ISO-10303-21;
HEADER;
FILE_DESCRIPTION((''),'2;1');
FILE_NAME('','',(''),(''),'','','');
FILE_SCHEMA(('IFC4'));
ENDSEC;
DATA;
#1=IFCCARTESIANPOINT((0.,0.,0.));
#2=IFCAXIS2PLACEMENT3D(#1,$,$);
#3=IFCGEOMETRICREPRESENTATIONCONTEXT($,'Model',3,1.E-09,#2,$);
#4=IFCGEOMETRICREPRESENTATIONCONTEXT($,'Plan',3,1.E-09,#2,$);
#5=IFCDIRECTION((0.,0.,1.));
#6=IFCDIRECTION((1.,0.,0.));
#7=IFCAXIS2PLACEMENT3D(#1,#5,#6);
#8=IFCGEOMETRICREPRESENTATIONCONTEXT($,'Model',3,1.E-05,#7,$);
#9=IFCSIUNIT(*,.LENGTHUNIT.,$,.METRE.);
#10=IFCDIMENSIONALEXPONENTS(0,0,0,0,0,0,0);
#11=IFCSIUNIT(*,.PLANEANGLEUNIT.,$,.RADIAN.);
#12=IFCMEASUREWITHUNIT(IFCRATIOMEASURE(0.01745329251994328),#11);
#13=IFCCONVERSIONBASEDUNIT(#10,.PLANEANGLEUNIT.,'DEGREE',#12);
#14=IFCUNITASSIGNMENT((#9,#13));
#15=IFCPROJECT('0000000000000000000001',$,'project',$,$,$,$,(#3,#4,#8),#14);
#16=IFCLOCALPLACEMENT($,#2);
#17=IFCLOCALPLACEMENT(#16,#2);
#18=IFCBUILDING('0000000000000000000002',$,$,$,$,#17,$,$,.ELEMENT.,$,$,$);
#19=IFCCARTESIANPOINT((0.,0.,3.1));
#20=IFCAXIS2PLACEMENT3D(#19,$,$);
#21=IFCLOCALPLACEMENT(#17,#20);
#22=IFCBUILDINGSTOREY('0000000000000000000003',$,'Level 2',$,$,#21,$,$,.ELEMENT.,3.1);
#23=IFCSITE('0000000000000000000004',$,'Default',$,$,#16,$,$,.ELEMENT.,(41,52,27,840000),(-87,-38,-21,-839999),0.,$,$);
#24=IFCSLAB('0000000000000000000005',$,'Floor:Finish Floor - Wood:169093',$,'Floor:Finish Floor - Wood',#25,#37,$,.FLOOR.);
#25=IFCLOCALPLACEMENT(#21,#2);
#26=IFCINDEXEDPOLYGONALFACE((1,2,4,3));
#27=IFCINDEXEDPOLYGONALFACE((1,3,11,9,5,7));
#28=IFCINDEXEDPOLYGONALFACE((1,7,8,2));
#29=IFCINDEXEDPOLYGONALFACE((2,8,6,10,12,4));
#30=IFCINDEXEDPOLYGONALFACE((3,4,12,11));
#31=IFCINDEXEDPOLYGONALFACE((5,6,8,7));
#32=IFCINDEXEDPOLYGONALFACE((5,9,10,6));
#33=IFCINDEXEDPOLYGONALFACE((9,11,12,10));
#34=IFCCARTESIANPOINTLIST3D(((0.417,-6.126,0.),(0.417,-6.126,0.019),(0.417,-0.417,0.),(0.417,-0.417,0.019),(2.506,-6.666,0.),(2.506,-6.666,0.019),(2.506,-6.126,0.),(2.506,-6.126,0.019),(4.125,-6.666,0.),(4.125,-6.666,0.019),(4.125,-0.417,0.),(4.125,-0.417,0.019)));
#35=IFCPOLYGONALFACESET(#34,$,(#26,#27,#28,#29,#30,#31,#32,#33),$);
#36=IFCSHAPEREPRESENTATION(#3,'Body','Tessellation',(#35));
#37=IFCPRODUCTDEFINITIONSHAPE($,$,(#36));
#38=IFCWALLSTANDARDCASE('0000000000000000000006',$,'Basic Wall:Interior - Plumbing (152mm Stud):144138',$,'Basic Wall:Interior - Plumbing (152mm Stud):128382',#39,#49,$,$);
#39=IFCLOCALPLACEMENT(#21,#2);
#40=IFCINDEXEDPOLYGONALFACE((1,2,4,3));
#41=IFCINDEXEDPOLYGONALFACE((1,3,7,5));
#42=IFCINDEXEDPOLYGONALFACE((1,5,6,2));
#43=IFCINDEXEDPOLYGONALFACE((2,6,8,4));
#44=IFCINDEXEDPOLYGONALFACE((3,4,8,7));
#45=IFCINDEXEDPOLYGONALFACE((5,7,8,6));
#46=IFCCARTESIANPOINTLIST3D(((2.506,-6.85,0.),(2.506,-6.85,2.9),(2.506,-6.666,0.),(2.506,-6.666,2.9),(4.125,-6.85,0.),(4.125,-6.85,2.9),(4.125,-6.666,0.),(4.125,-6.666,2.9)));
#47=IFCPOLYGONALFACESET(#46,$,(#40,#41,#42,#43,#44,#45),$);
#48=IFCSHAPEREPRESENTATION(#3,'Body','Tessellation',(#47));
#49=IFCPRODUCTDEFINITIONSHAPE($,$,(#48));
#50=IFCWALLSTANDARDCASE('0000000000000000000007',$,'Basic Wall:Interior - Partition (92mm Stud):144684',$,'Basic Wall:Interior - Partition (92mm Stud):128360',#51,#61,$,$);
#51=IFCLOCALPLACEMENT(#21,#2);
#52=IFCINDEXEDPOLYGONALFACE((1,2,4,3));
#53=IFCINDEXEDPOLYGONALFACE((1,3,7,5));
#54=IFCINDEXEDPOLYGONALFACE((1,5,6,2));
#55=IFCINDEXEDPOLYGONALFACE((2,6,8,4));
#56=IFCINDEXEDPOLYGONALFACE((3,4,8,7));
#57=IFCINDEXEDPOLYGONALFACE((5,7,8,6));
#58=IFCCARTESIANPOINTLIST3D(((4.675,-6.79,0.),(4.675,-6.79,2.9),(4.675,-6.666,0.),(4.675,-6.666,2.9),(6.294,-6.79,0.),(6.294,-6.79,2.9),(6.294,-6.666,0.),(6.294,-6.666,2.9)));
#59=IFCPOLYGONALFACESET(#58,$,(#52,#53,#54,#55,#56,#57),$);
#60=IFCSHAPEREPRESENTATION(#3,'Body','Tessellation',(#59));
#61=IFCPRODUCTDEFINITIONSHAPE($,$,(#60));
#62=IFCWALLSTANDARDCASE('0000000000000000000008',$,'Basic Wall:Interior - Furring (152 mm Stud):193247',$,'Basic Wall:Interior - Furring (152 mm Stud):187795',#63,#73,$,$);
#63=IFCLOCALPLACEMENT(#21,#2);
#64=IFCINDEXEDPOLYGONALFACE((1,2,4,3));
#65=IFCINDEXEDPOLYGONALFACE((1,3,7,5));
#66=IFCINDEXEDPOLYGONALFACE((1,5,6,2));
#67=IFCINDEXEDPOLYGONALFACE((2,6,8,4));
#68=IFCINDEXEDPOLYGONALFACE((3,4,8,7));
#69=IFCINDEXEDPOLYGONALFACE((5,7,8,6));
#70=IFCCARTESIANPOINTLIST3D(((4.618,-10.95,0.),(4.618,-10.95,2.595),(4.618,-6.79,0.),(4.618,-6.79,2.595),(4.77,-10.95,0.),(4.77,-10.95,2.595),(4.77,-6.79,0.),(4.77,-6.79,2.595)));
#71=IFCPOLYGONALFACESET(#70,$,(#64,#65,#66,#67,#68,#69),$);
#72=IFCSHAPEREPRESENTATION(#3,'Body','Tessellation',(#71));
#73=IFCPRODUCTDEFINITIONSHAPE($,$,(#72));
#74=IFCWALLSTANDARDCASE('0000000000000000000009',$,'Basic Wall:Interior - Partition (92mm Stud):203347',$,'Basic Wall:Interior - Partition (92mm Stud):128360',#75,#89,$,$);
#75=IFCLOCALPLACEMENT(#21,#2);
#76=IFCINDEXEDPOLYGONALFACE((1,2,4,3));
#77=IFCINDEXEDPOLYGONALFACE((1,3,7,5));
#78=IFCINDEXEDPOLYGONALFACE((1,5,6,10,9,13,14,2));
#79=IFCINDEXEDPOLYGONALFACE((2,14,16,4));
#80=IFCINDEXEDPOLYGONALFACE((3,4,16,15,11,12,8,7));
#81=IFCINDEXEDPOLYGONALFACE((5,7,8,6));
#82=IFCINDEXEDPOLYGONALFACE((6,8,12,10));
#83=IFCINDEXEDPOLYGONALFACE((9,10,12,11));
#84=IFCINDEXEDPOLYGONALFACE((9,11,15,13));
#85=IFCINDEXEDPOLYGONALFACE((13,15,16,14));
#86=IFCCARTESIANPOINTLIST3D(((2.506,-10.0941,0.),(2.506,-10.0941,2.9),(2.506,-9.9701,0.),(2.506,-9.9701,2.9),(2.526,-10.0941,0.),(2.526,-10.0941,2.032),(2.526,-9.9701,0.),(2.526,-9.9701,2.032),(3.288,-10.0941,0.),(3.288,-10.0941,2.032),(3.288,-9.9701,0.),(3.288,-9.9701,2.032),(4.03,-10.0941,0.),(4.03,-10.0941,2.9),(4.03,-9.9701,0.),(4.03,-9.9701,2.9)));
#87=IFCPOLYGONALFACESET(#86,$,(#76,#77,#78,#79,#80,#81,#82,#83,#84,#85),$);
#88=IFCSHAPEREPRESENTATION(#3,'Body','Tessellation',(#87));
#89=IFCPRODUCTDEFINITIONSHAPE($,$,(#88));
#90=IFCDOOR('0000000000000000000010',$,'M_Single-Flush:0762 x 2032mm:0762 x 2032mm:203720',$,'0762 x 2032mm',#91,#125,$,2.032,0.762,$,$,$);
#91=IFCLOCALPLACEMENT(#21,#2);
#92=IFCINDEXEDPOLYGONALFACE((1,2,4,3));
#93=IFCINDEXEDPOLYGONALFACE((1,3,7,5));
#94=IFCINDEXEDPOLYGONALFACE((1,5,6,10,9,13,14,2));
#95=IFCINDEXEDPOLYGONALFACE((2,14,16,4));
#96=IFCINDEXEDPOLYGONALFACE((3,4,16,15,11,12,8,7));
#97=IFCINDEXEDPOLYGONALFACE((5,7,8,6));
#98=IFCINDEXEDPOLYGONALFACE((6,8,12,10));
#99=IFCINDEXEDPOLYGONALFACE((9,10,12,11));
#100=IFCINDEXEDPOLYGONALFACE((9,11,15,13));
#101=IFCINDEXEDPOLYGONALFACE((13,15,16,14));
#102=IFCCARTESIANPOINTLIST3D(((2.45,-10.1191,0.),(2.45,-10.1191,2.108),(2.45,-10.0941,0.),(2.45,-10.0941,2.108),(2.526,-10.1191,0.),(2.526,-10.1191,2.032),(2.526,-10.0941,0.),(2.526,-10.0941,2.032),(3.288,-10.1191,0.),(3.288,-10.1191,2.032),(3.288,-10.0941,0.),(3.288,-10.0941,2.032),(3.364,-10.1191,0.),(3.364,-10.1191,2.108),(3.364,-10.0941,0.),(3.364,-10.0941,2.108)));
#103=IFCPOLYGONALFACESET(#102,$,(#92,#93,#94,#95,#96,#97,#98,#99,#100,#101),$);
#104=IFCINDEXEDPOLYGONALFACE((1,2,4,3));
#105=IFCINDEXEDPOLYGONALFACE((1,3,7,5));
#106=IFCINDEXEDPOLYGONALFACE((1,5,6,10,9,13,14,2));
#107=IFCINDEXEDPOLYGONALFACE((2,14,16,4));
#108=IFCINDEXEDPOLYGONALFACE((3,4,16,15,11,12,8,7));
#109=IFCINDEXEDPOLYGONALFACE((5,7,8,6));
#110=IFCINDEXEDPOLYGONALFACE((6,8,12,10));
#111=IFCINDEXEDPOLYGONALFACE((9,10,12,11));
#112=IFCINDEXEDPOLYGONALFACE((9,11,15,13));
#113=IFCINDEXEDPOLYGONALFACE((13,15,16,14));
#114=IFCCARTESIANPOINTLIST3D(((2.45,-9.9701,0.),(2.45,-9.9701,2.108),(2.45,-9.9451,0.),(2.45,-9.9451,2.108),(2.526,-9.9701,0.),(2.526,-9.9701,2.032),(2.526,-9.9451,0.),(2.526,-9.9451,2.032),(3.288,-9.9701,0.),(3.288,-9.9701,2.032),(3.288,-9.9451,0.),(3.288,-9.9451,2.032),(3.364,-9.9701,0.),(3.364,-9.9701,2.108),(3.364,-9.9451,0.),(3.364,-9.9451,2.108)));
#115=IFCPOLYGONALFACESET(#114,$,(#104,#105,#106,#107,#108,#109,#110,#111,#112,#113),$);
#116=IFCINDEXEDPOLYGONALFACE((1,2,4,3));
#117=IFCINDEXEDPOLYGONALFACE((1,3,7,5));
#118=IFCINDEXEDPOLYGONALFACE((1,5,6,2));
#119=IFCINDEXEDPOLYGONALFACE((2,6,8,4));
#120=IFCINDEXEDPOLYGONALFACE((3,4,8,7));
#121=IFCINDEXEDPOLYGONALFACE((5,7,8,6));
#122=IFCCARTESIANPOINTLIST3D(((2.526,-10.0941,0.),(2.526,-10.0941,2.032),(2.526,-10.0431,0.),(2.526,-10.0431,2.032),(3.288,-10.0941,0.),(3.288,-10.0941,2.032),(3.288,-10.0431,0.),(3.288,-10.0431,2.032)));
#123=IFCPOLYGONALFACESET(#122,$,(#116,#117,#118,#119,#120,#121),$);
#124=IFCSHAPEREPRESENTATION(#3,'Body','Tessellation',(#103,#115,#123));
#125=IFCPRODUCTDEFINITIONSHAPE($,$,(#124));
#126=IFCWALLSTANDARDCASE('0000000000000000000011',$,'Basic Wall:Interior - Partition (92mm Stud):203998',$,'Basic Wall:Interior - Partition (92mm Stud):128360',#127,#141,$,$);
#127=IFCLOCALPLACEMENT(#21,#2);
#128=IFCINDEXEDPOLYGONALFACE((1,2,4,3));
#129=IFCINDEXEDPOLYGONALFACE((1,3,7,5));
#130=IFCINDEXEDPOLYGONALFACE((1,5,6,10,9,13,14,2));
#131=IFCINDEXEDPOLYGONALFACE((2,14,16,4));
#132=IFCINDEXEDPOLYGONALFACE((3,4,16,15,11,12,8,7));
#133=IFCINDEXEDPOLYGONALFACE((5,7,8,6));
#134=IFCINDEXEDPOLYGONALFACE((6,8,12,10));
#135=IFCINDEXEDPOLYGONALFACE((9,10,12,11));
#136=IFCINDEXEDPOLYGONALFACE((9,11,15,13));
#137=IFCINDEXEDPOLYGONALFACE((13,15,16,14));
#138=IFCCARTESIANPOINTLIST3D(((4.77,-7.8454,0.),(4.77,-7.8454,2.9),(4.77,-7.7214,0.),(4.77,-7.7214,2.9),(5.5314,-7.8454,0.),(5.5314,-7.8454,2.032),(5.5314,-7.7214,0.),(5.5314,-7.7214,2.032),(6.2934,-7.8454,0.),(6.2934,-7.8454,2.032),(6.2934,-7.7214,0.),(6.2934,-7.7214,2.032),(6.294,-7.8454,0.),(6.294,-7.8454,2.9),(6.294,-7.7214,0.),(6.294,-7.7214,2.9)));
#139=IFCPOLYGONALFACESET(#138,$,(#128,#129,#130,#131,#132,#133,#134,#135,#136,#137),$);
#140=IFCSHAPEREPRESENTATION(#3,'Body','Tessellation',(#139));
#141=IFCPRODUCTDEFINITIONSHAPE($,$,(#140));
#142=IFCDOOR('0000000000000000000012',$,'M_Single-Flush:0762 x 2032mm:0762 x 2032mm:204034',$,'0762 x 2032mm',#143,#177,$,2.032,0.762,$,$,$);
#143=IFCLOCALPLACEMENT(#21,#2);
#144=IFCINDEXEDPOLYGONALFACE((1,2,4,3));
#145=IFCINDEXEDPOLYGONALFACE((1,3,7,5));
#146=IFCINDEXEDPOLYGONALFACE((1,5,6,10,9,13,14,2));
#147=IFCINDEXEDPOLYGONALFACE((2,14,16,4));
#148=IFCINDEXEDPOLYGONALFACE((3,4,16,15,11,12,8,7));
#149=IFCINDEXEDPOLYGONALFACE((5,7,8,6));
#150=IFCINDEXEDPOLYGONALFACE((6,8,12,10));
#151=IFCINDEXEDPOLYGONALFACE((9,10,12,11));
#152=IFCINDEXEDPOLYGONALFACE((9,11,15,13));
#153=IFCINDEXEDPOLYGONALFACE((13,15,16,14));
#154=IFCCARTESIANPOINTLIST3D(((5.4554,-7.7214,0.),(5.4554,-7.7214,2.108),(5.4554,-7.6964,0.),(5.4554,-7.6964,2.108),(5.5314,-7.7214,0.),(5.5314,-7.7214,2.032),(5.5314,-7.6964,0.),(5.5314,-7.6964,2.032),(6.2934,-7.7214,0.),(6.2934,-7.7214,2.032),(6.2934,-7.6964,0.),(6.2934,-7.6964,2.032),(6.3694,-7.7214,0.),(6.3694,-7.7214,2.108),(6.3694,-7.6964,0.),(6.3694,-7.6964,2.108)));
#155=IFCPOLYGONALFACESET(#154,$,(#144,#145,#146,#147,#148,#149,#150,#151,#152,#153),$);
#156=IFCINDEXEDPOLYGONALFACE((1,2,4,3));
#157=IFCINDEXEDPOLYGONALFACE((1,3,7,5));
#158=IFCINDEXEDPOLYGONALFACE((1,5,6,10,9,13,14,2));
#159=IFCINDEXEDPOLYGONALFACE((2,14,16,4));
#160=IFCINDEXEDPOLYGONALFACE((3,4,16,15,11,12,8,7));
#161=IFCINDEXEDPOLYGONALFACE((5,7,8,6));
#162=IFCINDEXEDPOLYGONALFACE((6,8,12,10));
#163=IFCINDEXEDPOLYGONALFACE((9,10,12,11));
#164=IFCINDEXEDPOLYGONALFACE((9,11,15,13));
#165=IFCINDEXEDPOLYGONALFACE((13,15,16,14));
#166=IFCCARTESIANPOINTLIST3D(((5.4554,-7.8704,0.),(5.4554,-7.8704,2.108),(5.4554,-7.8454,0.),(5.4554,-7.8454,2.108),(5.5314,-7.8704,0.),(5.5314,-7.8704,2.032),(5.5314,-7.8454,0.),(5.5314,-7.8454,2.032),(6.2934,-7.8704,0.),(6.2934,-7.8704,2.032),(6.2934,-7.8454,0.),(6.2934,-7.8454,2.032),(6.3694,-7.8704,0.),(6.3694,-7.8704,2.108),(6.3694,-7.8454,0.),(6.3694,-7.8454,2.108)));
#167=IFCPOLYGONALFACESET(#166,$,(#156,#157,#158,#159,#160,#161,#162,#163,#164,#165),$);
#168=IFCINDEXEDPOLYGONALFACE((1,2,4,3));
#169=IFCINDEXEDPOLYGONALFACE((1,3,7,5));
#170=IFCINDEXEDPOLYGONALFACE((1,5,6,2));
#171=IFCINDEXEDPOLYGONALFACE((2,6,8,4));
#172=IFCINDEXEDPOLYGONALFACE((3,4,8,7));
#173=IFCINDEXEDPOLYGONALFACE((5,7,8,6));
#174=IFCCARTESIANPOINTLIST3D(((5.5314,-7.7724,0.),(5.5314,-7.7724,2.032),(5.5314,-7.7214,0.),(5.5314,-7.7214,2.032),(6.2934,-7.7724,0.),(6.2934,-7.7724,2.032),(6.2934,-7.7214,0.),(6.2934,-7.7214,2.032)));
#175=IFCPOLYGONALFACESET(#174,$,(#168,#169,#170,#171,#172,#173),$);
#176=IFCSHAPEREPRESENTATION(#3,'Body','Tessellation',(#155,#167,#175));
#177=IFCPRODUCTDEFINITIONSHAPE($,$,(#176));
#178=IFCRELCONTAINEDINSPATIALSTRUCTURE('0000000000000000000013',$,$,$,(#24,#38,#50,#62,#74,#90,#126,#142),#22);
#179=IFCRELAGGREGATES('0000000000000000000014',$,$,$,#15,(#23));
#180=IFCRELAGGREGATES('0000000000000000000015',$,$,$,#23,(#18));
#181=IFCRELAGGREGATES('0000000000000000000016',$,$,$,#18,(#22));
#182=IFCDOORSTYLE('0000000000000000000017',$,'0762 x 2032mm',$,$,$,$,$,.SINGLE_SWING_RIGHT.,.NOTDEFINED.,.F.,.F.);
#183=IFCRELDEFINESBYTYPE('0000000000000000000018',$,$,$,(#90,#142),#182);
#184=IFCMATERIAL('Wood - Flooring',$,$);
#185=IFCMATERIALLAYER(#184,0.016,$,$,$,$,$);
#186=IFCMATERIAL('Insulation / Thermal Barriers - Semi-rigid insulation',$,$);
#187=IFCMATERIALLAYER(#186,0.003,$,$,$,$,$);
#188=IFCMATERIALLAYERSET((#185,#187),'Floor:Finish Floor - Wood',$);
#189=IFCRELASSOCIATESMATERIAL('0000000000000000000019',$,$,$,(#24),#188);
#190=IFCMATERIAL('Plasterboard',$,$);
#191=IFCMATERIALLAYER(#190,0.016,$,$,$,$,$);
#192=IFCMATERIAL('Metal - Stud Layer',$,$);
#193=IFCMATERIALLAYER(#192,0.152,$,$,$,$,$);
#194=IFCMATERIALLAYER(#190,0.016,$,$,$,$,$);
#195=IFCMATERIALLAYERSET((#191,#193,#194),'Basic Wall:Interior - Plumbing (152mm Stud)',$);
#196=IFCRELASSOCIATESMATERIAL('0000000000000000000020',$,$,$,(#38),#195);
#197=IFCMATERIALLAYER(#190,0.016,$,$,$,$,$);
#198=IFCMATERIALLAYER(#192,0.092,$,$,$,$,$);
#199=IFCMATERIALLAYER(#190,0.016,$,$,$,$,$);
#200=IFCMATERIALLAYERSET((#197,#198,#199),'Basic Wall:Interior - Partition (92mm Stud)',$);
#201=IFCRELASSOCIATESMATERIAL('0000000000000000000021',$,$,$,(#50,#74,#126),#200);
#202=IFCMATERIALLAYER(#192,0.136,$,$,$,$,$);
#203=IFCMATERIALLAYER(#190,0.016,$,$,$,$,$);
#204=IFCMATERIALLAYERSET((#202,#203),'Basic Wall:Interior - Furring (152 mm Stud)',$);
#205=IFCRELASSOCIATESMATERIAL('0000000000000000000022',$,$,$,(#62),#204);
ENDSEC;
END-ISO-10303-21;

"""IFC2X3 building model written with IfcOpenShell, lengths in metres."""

from ifc_helpers import new_model, entity, si_unit, converted_unit, frame, frame_2d, origin, origin_with_axes, origin_2d_with_axis, place, context, project, spatial, polyline, rectangle, outline, extrude, source, transform, mapped, material, layer, layer_set, layer_usage, type_object, type_shapes, element, fill, save


model = new_model("IFC2X3")

# Units and contexts
model_context_1 = context("Model", 3, precision=1e-09, world=origin())
plan_context = context("Plan", 3, precision=1e-09, world=origin())
model_context_2 = context("Model", 3, precision=1e-05, world=origin_with_axes())
ifc_project = project(units=[si_unit("LENGTHUNIT", "METRE"), converted_unit("PLANEANGLEUNIT", "DEGREE", entity("IfcRatioMeasure", 0.01745329251994328), si_unit("PLANEANGLEUNIT", "RADIAN"), dimensions=[0, 0, 0, 0, 0, 0, 0])], contexts=[model_context_1, plan_context, model_context_2])

# Site, building, storey
site_placement = place(None, origin())
site = spatial("IfcSite", under=ifc_project, at=site_placement, Name="Default", CompositionType="ELEMENT", RefLatitude=(41, 52, 27, 840000), RefLongitude=(-87, -38, -21, -839999), RefElevation=0.0)
building_placement = place(site_placement, origin())
building = spatial("IfcBuilding", under=site, at=building_placement, CompositionType="ELEMENT")
storey_placement = place(building_placement, frame((0.0, 0.0, 3.1)))
storey = spatial("IfcBuildingStorey", under=building, at=storey_placement, Name="Level 2", CompositionType="ELEMENT", Elevation=3.1)

# Slab
ifc_material_1 = material(Name="Wood - Flooring")
ifc_layer_1 = layer(ifc_material_1, 0.016)
ifc_material_2 = material(Name="Insulation / Thermal Barriers - Semi-rigid insulation")
ifc_layer_2 = layer(ifc_material_2, 0.003)
ifc_layer_set_1 = layer_set([ifc_layer_1, ifc_layer_2], Name="Floor:Finish Floor - Wood")
ifc_layer_usage_1 = layer_usage(ifc_layer_set_1, "AXIS3", "POSITIVE", 0.0)
slab_placement = place(storey_placement, frame((0.417, -6.666, 0.0)))
element("IfcSlab", 1, at=slab_placement, inside=storey, material=ifc_layer_usage_1, Name="Floor:Finish Floor - Wood:169093", ObjectType="Floor:Finish Floor - Wood", PredefinedType="FLOOR", context=model_context_1, shape_type="SweptSolid", body=[
    extrude(outline(polyline([(1.854, 3.1245), (-1.854, 3.1245), (-1.854, -3.1245), (-0.235, -3.1245), (-0.235, -2.5845), (1.854, -2.5845), (1.854, 3.1245)])), frame((1.854, 3.1245, 0.019), z_axis=(0.0, 0.0, -1.0), x_axis=(-1.0, 0.0, 0.0)), (0.0, 0.0, 1.0), 0.019),
])

# Walls
ifc_material_3 = material(Name="Plasterboard")
ifc_layer_3 = layer(ifc_material_3, 0.016)
ifc_material_4 = material(Name="Metal - Stud Layer")
ifc_layer_4 = layer(ifc_material_4, 0.152)
ifc_layer_5 = layer(ifc_material_3, 0.016)
ifc_layer_set_2 = layer_set([ifc_layer_3, ifc_layer_4, ifc_layer_5], Name="Basic Wall:Interior - Plumbing (152mm Stud)")
ifc_layer_usage_2 = layer_usage(ifc_layer_set_2, "AXIS2", "NEGATIVE", 0.092)
wall_1_placement = place(storey_placement, frame((2.506, -6.758, 0.0)))
element("IfcWallStandardCase", 2, at=wall_1_placement, inside=storey, material=ifc_layer_usage_2, Name="Basic Wall:Interior - Plumbing (152mm Stud):144138", ObjectType="Basic Wall:Interior - Plumbing (152mm Stud):128382", context=model_context_1, shape_type="SweptSolid", body=[
    extrude(rectangle(XDim=1.619, YDim=0.184, at=frame_2d((0.8095, 0.0), x_axis=(-1.0, 0.0))), origin(), (0.0, 0.0, 1.0), 2.9),
])
ifc_layer_6 = layer(ifc_material_3, 0.016)
ifc_layer_7 = layer(ifc_material_4, 0.092)
ifc_layer_8 = layer(ifc_material_3, 0.016)
ifc_layer_set_3 = layer_set([ifc_layer_6, ifc_layer_7, ifc_layer_8], Name="Basic Wall:Interior - Partition (92mm Stud)")
ifc_layer_usage_3 = layer_usage(ifc_layer_set_3, "AXIS2", "NEGATIVE", 0.062)
wall_2_placement = place(storey_placement, frame((4.675, -6.728, 0.0)))
element("IfcWallStandardCase", 3, at=wall_2_placement, inside=storey, material=ifc_layer_usage_3, Name="Basic Wall:Interior - Partition (92mm Stud):144684", ObjectType="Basic Wall:Interior - Partition (92mm Stud):128360", context=model_context_1, shape_type="SweptSolid", body=[
    extrude(rectangle(XDim=1.619, YDim=0.124, at=frame_2d((0.8095, 0.0), x_axis=(-1.0, 0.0))), origin(), (0.0, 0.0, 1.0), 2.9),
])
ifc_layer_9 = layer(ifc_material_4, 0.136)
ifc_layer_10 = layer(ifc_material_3, 0.016)
ifc_layer_set_4 = layer_set([ifc_layer_9, ifc_layer_10], Name="Basic Wall:Interior - Furring (152 mm Stud)")
ifc_layer_usage_4 = layer_usage(ifc_layer_set_4, "AXIS2", "POSITIVE", -0.076)
wall_3_placement = place(storey_placement, frame((4.694, -6.79, 0.0), z_axis=(0.0, 0.0, 1.0), x_axis=(0.0, -1.0, 0.0)))
element("IfcWallStandardCase", 4, at=wall_3_placement, inside=storey, material=ifc_layer_usage_4, Name="Basic Wall:Interior - Furring (152 mm Stud):193247", ObjectType="Basic Wall:Interior - Furring (152 mm Stud):187795", context=model_context_1, shape_type="SweptSolid", body=[
    extrude(rectangle(XDim=4.16, YDim=0.152, at=frame_2d((2.08, 0.0), x_axis=(-1.0, 0.0))), origin(), (0.0, 0.0, 1.0), 2.595),
])

# Walls, openings, doors
ifc_layer_usage_5 = layer_usage(ifc_layer_set_3, "AXIS2", "NEGATIVE", 0.062)
wall_4_placement = place(storey_placement, frame((4.03, -10.0321, 0.0), z_axis=(0.0, 0.0, 1.0), x_axis=(-1.0, 0.0, 0.0)))
wall_4 = element("IfcWallStandardCase", 5, at=wall_4_placement, inside=storey, material=ifc_layer_usage_5, Name="Basic Wall:Interior - Partition (92mm Stud):203347", ObjectType="Basic Wall:Interior - Partition (92mm Stud):128360", context=model_context_1, shape_type="SweptSolid", body=[
    extrude(rectangle(XDim=1.524, YDim=0.124, at=frame_2d((0.762, 0.0), x_axis=(-1.0, 0.0))), origin(), (0.0, 0.0, 1.0), 2.9),
])
opening_1_placement = place(wall_4_placement, frame((0.742, -0.062, 0.0)))
opening_1 = element("IfcOpeningElement", 6, at=opening_1_placement, cuts=wall_4, ObjectType="Opening", context=model_context_1, shape_type="SweptSolid", body=[
    extrude(rectangle(XDim=0.762, YDim=2.032, at=frame_2d((1.016, 0.381), x_axis=(0.0, 1.0))), frame((0.0, 0.0, 0.0), z_axis=(0.0, 1.0, 0.0), x_axis=(0.0, 0.0, 1.0)), (0.0, 0.0, 1.0), 0.124),
])
door_style = type_object("IfcDoorStyle", Name="0762 x 2032mm", ConstructionType="NOTDEFINED", OperationType="SINGLE_SWING_RIGHT", ParameterTakesPrecedence=False, Sizeable=False)
shared_shape = source(origin(), model_context_1, "Body", "SweptSolid", [
    extrude(outline(polyline([(-0.457, -1.073), (0.457, -1.073), (0.457, 1.035), (0.381, 1.035), (0.381, -0.997), (-0.381, -0.997), (-0.381, 1.035), (-0.457, 1.035), (-0.457, -1.073)])), frame((0.381, 0.124, 1.035), z_axis=(0.0, 1.0, 0.0), x_axis=(1.0, 0.0, 0.0)), (0.0, 0.0, 1.0), 0.025),
    extrude(outline(polyline([(-1.073, -0.457), (1.035, -0.457), (1.035, -0.381), (-0.997, -0.381), (-0.997, 0.381), (1.035, 0.381), (1.035, 0.457), (-1.073, 0.457), (-1.073, -0.457)])), frame((0.381, -0.025, 1.035), z_axis=(0.0, 1.0, 0.0), x_axis=(0.0, 0.0, -1.0)), (0.0, 0.0, 1.0), 0.025),
    extrude(rectangle(XDim=0.051, YDim=0.762, at=origin_2d_with_axis()), frame((0.381, 0.0985, 0.0), z_axis=(0.0, 0.0, 1.0), x_axis=(0.0, 1.0, 0.0)), (0.0, 0.0, 1.0), 2.032),
])
type_shapes(door_style, [shared_shape])
door_1_placement = place(opening_1_placement, origin())
door_1 = element("IfcDoor", 7, at=door_1_placement, inside=storey, type_object=door_style, Name="M_Single-Flush:0762 x 2032mm:0762 x 2032mm:203720", ObjectType="0762 x 2032mm", OverallHeight=2.032, OverallWidth=0.762, context=model_context_1, shape_type="MappedRepresentation", body=[
    mapped(shared_shape, transform((0.0, 0.0, 0.0), scale=1.0)),
])
fill(opening_1, door_1)
ifc_layer_usage_6 = layer_usage(ifc_layer_set_3, "AXIS2", "POSITIVE", -0.062)
wall_5_placement = place(storey_placement, frame((4.77, -7.7834, 0.0)))
wall_5 = element("IfcWallStandardCase", 8, at=wall_5_placement, inside=storey, material=ifc_layer_usage_6, Name="Basic Wall:Interior - Partition (92mm Stud):203998", ObjectType="Basic Wall:Interior - Partition (92mm Stud):128360", context=model_context_1, shape_type="SweptSolid", body=[
    extrude(rectangle(XDim=1.524, YDim=0.124, at=frame_2d((0.762, 0.0), x_axis=(-1.0, 0.0))), origin(), (0.0, 0.0, 1.0), 2.9),
])
opening_2_placement = place(wall_5_placement, frame((0.7614, -0.062, 0.0)))
opening_2 = element("IfcOpeningElement", 9, at=opening_2_placement, cuts=wall_5, ObjectType="Opening", context=model_context_1, shape_type="SweptSolid", body=[
    extrude(rectangle(XDim=0.762, YDim=2.032, at=frame_2d((1.016, 0.381), x_axis=(0.0, 1.0))), frame((0.0, 0.0, 0.0), z_axis=(0.0, 1.0, 0.0), x_axis=(0.0, 0.0, 1.0)), (0.0, 0.0, 1.0), 0.124),
])
door_2_placement = place(opening_2_placement, origin())
door_2 = element("IfcDoor", 10, at=door_2_placement, inside=storey, type_object=door_style, Name="M_Single-Flush:0762 x 2032mm:0762 x 2032mm:204034", ObjectType="0762 x 2032mm", OverallHeight=2.032, OverallWidth=0.762, context=model_context_1, shape_type="MappedRepresentation", body=[
    mapped(shared_shape, transform((0.0, 0.0, 0.0), scale=1.0)),
])
fill(opening_2, door_2)

save(model, "model.ifc")
